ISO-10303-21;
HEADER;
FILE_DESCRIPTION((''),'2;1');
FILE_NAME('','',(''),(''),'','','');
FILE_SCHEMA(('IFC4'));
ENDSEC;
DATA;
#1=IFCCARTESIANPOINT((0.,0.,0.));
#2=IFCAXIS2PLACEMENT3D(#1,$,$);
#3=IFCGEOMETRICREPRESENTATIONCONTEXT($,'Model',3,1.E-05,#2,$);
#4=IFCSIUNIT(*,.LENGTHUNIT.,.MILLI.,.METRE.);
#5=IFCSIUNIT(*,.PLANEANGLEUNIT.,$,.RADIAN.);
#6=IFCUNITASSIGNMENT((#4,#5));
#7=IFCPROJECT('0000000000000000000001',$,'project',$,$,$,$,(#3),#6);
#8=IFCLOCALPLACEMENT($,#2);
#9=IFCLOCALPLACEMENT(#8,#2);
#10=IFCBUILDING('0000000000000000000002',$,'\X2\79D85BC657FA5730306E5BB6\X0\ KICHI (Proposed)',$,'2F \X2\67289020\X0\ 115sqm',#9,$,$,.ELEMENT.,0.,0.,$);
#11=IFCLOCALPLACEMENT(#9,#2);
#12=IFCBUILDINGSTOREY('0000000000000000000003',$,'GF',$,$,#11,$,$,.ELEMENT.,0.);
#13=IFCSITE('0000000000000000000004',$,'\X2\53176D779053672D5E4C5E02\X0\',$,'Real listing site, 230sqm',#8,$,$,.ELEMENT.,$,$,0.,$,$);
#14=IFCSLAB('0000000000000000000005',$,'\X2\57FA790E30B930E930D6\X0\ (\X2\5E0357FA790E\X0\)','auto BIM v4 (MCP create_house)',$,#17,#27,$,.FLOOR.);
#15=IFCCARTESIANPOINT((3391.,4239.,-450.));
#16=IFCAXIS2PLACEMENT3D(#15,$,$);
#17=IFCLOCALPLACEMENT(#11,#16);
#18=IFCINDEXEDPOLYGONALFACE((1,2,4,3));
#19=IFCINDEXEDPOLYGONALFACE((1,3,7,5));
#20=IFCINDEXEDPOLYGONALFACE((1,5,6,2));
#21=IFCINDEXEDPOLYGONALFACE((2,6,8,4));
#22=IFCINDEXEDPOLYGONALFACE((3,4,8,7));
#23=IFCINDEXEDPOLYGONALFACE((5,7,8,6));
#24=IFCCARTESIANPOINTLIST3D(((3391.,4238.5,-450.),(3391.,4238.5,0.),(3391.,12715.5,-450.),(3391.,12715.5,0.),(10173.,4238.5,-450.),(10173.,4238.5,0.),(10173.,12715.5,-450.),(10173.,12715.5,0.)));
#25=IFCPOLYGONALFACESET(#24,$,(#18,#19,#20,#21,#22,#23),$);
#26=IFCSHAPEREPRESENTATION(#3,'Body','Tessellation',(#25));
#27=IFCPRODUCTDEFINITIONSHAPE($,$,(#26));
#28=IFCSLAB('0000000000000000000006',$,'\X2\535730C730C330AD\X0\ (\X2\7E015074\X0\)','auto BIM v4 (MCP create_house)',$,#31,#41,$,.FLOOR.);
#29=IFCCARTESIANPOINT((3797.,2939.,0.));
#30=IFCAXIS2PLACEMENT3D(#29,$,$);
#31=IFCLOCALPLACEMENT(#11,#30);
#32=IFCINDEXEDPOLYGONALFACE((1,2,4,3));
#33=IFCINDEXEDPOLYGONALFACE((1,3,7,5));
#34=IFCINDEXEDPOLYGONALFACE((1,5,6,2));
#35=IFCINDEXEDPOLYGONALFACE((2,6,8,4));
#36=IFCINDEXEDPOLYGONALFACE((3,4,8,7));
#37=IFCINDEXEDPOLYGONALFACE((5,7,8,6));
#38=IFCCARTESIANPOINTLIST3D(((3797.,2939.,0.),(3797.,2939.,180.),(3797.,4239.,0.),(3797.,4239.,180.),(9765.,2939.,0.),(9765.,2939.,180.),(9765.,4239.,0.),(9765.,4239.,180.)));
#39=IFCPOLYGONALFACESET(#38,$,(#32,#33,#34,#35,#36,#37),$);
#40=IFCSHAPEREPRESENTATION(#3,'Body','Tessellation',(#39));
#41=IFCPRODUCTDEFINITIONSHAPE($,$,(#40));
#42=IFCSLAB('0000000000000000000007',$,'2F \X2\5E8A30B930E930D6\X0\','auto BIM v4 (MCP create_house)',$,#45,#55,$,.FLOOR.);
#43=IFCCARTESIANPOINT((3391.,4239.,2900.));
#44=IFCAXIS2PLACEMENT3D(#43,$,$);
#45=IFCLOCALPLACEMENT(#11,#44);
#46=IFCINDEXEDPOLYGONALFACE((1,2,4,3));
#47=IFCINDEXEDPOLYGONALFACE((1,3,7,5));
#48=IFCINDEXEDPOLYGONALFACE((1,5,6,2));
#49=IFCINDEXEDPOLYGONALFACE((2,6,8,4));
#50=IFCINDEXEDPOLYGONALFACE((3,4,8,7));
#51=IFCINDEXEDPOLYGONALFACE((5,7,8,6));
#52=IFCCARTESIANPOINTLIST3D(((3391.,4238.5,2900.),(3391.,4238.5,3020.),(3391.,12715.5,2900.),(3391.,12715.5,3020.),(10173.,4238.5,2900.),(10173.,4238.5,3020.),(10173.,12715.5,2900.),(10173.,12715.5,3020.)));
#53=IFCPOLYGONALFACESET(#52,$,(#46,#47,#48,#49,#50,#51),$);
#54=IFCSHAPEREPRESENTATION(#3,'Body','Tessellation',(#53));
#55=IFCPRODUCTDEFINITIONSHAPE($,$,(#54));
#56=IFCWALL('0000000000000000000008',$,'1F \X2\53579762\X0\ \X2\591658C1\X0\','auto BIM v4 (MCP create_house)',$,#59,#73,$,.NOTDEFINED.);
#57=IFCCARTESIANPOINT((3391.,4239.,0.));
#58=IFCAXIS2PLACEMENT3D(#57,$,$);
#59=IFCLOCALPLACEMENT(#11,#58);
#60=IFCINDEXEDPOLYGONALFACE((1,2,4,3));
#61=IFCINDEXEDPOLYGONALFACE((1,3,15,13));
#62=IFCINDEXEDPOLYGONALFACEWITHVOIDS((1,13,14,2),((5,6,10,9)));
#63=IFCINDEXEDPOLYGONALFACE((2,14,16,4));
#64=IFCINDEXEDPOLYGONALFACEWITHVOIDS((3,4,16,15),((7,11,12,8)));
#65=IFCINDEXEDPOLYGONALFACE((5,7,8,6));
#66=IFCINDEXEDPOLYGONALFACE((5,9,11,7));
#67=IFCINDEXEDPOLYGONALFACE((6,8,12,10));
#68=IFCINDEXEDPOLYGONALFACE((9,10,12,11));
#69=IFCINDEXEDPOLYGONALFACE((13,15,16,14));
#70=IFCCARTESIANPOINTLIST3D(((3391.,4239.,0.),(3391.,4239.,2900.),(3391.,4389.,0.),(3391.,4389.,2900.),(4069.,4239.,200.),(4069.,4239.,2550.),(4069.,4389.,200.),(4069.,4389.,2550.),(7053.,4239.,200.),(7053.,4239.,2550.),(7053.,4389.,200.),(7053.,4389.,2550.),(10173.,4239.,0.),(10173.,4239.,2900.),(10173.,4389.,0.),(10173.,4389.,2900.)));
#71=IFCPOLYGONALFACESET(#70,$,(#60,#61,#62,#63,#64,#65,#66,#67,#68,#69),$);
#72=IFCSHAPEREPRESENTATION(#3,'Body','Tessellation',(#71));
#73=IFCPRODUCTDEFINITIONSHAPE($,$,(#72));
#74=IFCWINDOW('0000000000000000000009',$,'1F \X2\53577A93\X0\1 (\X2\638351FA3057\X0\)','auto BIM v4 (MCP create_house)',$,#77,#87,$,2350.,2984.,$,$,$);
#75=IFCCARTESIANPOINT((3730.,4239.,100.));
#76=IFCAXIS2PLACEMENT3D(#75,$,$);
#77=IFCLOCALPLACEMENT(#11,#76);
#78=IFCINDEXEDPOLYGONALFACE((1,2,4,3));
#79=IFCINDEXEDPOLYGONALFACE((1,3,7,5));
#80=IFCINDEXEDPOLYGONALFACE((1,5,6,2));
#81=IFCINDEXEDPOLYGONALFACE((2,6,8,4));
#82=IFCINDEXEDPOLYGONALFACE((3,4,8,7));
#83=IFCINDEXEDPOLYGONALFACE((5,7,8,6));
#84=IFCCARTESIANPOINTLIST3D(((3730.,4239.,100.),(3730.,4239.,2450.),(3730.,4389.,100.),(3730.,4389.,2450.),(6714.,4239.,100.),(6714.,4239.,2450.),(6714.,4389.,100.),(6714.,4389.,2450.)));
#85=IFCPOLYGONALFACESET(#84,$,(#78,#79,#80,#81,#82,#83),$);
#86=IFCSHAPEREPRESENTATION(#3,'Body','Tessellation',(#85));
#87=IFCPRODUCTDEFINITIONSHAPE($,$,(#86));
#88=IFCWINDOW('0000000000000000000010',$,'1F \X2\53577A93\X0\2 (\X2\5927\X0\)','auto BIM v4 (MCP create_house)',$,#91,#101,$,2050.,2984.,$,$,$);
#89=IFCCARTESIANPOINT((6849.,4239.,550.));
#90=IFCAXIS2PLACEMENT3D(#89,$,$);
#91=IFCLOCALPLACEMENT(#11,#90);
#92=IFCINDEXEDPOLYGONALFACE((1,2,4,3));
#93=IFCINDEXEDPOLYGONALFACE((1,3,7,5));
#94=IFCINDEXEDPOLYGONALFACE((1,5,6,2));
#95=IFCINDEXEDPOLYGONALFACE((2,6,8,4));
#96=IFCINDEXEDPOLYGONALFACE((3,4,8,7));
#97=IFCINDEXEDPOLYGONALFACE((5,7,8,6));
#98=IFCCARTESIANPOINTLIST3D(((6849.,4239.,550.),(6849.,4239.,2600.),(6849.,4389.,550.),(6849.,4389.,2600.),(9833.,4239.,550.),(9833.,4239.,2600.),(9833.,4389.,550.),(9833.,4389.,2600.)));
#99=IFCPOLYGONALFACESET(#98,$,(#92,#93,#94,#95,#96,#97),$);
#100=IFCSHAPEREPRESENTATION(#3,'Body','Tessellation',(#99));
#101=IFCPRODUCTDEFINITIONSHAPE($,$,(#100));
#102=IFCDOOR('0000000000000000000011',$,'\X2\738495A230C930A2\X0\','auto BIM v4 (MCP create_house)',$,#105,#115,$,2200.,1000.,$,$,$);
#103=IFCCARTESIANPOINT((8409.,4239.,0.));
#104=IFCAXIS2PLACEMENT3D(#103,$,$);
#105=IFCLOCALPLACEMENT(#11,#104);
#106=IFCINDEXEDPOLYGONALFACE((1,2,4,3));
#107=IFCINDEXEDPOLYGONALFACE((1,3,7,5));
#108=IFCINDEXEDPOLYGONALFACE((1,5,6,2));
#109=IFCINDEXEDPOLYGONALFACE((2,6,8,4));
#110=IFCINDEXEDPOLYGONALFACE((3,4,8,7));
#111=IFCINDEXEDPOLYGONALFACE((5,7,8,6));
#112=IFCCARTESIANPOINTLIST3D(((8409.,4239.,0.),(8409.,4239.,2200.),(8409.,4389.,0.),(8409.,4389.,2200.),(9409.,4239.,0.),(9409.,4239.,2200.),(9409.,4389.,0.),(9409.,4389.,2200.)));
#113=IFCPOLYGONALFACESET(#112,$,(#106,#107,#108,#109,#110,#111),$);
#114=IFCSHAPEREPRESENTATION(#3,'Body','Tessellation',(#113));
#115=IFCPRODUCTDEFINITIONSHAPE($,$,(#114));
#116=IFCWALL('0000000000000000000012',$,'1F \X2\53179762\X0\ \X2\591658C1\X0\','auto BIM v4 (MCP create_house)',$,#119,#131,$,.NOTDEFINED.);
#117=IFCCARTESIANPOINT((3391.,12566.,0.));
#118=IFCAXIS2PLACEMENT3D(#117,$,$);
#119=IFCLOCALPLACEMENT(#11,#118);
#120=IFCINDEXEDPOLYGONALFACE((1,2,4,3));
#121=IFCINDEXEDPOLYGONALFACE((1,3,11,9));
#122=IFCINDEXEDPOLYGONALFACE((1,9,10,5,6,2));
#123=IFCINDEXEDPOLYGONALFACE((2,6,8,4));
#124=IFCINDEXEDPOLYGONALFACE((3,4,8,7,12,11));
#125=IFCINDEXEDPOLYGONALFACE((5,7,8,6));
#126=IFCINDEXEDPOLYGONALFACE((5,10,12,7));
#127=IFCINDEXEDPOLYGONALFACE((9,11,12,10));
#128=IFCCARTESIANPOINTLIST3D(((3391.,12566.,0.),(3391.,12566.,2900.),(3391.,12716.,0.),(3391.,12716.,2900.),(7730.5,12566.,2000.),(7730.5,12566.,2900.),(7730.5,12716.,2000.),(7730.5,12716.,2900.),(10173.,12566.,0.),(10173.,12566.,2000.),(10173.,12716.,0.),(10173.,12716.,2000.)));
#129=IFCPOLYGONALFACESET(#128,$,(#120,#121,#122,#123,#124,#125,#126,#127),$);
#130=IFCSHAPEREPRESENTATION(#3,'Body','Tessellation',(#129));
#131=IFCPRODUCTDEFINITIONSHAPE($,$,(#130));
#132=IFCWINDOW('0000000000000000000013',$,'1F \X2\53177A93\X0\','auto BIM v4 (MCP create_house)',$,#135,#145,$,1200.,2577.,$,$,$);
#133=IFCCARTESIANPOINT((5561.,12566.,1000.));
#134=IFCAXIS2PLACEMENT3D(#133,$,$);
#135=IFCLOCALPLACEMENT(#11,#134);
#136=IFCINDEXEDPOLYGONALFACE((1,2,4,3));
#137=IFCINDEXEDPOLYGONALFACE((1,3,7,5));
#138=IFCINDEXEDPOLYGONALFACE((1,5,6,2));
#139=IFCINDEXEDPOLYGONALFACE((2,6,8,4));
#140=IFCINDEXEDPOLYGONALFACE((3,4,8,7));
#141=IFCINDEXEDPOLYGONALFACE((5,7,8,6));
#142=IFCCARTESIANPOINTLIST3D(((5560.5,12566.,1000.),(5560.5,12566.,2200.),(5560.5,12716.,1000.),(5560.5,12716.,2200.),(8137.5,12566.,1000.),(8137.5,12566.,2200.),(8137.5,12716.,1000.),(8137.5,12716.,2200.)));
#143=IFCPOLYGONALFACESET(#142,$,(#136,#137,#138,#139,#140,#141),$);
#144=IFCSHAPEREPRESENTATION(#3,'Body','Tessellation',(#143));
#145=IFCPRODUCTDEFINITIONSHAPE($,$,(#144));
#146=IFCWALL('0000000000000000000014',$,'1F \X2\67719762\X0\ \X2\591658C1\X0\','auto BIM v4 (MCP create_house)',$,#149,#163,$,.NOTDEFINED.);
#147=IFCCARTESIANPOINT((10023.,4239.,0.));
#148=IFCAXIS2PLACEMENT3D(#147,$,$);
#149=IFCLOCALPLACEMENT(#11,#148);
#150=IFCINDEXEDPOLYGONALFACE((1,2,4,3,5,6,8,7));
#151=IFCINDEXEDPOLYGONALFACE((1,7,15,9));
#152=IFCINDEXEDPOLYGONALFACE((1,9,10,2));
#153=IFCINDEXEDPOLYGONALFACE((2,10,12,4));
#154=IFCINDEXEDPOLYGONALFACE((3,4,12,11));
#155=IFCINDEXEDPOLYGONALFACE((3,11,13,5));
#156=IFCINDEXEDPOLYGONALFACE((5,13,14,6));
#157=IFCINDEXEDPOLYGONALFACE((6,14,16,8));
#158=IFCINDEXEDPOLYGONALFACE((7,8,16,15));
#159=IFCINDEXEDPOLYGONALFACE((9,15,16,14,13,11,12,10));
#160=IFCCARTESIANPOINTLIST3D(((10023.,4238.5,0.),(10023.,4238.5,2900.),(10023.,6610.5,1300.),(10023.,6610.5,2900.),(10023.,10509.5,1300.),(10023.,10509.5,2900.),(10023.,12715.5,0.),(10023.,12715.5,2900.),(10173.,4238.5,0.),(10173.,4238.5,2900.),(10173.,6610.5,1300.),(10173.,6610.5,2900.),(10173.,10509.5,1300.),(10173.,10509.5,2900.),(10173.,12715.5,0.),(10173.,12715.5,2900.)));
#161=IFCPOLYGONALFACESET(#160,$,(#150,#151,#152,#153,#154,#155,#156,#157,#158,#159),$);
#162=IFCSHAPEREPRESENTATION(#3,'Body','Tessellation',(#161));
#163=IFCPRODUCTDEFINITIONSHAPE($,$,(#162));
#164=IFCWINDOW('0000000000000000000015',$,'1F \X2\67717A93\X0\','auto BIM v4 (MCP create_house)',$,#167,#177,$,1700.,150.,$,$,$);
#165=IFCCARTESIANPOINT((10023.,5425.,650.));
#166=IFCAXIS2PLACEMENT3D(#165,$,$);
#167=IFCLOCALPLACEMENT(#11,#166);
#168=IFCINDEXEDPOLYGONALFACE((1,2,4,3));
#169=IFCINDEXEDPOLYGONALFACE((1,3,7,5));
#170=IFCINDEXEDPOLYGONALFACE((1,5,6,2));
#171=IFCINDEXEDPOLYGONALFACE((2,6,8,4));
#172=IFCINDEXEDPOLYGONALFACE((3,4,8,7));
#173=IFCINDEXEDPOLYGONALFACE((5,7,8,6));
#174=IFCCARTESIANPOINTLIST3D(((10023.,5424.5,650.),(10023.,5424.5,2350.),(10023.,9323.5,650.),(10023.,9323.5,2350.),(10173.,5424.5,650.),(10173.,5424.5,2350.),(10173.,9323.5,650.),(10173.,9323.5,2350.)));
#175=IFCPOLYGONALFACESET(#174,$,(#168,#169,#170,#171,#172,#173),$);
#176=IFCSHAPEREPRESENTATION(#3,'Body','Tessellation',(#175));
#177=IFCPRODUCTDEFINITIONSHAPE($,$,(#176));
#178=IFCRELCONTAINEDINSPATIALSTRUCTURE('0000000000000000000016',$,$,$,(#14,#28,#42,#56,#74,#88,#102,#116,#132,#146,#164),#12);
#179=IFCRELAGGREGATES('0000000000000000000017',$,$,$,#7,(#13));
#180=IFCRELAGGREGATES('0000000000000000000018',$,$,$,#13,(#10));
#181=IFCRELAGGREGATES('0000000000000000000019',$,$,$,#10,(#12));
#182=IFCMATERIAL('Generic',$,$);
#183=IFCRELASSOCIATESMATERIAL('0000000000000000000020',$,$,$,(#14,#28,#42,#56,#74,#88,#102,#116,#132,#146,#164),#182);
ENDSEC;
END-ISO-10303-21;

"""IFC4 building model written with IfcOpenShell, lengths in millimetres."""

from ifc_helpers import new_model, si_unit, frame, frame_2d, origin, place, context, project, spatial, rectangle, extrude, material, element, fill, save


model = new_model("IFC4")

# Units and contexts
model_context = context("Model", 3, precision=1e-05, world=origin())
ifc_project = project(units=[si_unit("LENGTHUNIT", "METRE", prefix="MILLI"), si_unit("PLANEANGLEUNIT", "RADIAN")], contexts=[model_context])

# Site, building, storey
site_placement = place(None, origin())
site = spatial("IfcSite", under=ifc_project, at=site_placement, Name="北海道札幌市", ObjectType="Real listing site, 230sqm", CompositionType="ELEMENT", RefElevation=0.0)
building_placement = place(site_placement, origin())
building = spatial("IfcBuilding", under=site, at=building_placement, Name="秘密基地の家 KICHI (Proposed)", ObjectType="2F 木造 115sqm", CompositionType="ELEMENT", ElevationOfRefHeight=0.0, ElevationOfTerrain=0.0)
storey_placement = place(building_placement, origin())
storey = spatial("IfcBuildingStorey", under=building, at=storey_placement, Name="GF", CompositionType="ELEMENT", Elevation=0.0)

# Slabs
ifc_material = material(Name="Generic")
slab_1_placement = place(storey_placement, frame((3391.0, 4239.0, -450.0)))
element("IfcSlab", 1, at=slab_1_placement, inside=storey, material=ifc_material, Name="基礎スラブ (布基礎)", Description="auto BIM v4 (MCP create_house)", PredefinedType="FLOOR", context=model_context, shape_type="SweptSolid", body=[
    extrude(rectangle(XDim=6782.0, YDim=8477.0, at=frame_2d((3391.0, 4238.0))), frame((3391.0, 4239.0, -450.0)), (0.0, 0.0, 1.0), 450.0),
])
slab_2_placement = place(storey_placement, frame((3797.0, 2939.0, 0.0)))
element("IfcSlab", 2, at=slab_2_placement, inside=storey, material=ifc_material, Name="南デッキ (縁側)", Description="auto BIM v4 (MCP create_house)", PredefinedType="FLOOR", context=model_context, shape_type="SweptSolid", body=[
    extrude(rectangle(XDim=5968.0, YDim=1300.0, at=frame_2d((2984.0, 650.0))), frame((3797.0, 2939.0, 0.0)), (0.0, 0.0, 1.0), 180.0),
])
slab_3_placement = place(storey_placement, frame((3391.0, 4239.0, 2900.0)))
element("IfcSlab", 3, at=slab_3_placement, inside=storey, material=ifc_material, Name="2F 床スラブ", Description="auto BIM v4 (MCP create_house)", PredefinedType="FLOOR", context=model_context, shape_type="SweptSolid", body=[
    extrude(rectangle(XDim=6782.0, YDim=8477.0, at=frame_2d((3391.0, 4238.0))), frame((3391.0, 4239.0, 2900.0)), (0.0, 0.0, 1.0), 120.0),
])

# Wall, openings, windows, door
wall_1_placement = place(storey_placement, frame((3391.0, 4239.0, 0.0)))
wall_1 = element("IfcWall", 4, at=wall_1_placement, inside=storey, material=ifc_material, Name="1F 南面 外壁", Description="auto BIM v4 (MCP create_house)", PredefinedType="NOTDEFINED", context=model_context, shape_type="SweptSolid", body=[
    extrude(rectangle(XDim=6782.0, YDim=150.0, at=frame_2d((3391.0, 75.0))), frame((3391.0, 4239.0, 0.0)), (0.0, 0.0, 1.0), 2900.0),
])
opening_1_placement = place(storey_placement, frame((3730.0, 4239.0, 100.0)))
opening_1 = element("IfcOpeningElement", 5, at=opening_1_placement, cuts=wall_1, PredefinedType="NOTDEFINED", context=model_context, shape_type="SweptSolid", body=[
    extrude(rectangle(XDim=2984.0, YDim=150.0, at=frame_2d((1492.0, 75.0))), frame((3730.0, 4239.0, 100.0)), (0.0, 0.0, 1.0), 2350.0),
])
opening_2_placement = place(storey_placement, frame((6849.0, 4239.0, 550.0)))
opening_2 = element("IfcOpeningElement", 6, at=opening_2_placement, cuts=wall_1, PredefinedType="NOTDEFINED", context=model_context, shape_type="SweptSolid", body=[
    extrude(rectangle(XDim=2984.0, YDim=150.0, at=frame_2d((1492.0, 75.0))), frame((6849.0, 4239.0, 550.0)), (0.0, 0.0, 1.0), 2050.0),
])
opening_3_placement = place(storey_placement, frame((8409.0, 4239.0, 0.0)))
opening_3 = element("IfcOpeningElement", 7, at=opening_3_placement, cuts=wall_1, PredefinedType="NOTDEFINED", context=model_context, shape_type="SweptSolid", body=[
    extrude(rectangle(XDim=1000.0, YDim=150.0, at=frame_2d((500.0, 75.0))), frame((8409.0, 4239.0, 0.0)), (0.0, 0.0, 1.0), 2200.0),
])
window_1_placement = place(storey_placement, frame((3730.0, 4239.0, 100.0)))
window_1 = element("IfcWindow", 8, at=window_1_placement, inside=storey, material=ifc_material, Name="1F 南窓1 (掃出し)", Description="auto BIM v4 (MCP create_house)", OverallHeight=2350.0, OverallWidth=2984.0, context=model_context, shape_type="SweptSolid", body=[
    extrude(rectangle(XDim=2984.0, YDim=150.0, at=frame_2d((1492.0, 75.0))), frame((3730.0, 4239.0, 100.0)), (0.0, 0.0, 1.0), 2350.0),
])
fill(opening_1, window_1)
window_2_placement = place(storey_placement, frame((6849.0, 4239.0, 550.0)))
window_2 = element("IfcWindow", 9, at=window_2_placement, inside=storey, material=ifc_material, Name="1F 南窓2 (大)", Description="auto BIM v4 (MCP create_house)", OverallHeight=2050.0, OverallWidth=2984.0, context=model_context, shape_type="SweptSolid", body=[
    extrude(rectangle(XDim=2984.0, YDim=150.0, at=frame_2d((1492.0, 75.0))), frame((6849.0, 4239.0, 550.0)), (0.0, 0.0, 1.0), 2050.0),
])
fill(opening_2, window_2)
door_1_placement = place(storey_placement, frame((8409.0, 4239.0, 0.0)))
door_1 = element("IfcDoor", 10, at=door_1_placement, inside=storey, material=ifc_material, Name="玄関ドア", Description="auto BIM v4 (MCP create_house)", OverallHeight=2200.0, OverallWidth=1000.0, context=model_context, shape_type="SweptSolid", body=[
    extrude(rectangle(XDim=1000.0, YDim=150.0, at=frame_2d((500.0, 75.0))), frame((8409.0, 4239.0, 0.0)), (0.0, 0.0, 1.0), 2200.0),
])
fill(opening_3, door_1)

# Walls, openings, windows
wall_2_placement = place(storey_placement, frame((3391.0, 12566.0, 0.0)))
wall_2 = element("IfcWall", 11, at=wall_2_placement, inside=storey, material=ifc_material, Name="1F 北面 外壁", Description="auto BIM v4 (MCP create_house)", PredefinedType="NOTDEFINED", context=model_context, shape_type="SweptSolid", body=[
    extrude(rectangle(XDim=6782.0, YDim=150.0, at=frame_2d((3391.0, 75.0))), frame((3391.0, 12566.0, 0.0)), (0.0, 0.0, 1.0), 2900.0),
])
opening_4_placement = place(storey_placement, frame((5561.0, 12566.0, 1000.0)))
opening_4 = element("IfcOpeningElement", 12, at=opening_4_placement, cuts=wall_2, PredefinedType="NOTDEFINED", context=model_context, shape_type="SweptSolid", body=[
    extrude(rectangle(XDim=2577.0, YDim=150.0, at=frame_2d((1288.0, 75.0))), frame((5561.0, 12566.0, 1000.0)), (0.0, 0.0, 1.0), 1200.0),
])
window_3_placement = place(storey_placement, frame((5561.0, 12566.0, 1000.0)))
window_3 = element("IfcWindow", 13, at=window_3_placement, inside=storey, material=ifc_material, Name="1F 北窓", Description="auto BIM v4 (MCP create_house)", OverallHeight=1200.0, OverallWidth=2577.0, context=model_context, shape_type="SweptSolid", body=[
    extrude(rectangle(XDim=2577.0, YDim=150.0, at=frame_2d((1288.0, 75.0))), frame((5561.0, 12566.0, 1000.0)), (0.0, 0.0, 1.0), 1200.0),
])
fill(opening_4, window_3)
wall_3_placement = place(storey_placement, frame((10023.0, 4239.0, 0.0)))
wall_3 = element("IfcWall", 14, at=wall_3_placement, inside=storey, material=ifc_material, Name="1F 東面 外壁", Description="auto BIM v4 (MCP create_house)", PredefinedType="NOTDEFINED", context=model_context, shape_type="SweptSolid", body=[
    extrude(rectangle(XDim=150.0, YDim=8477.0, at=frame_2d((75.0, 4238.0))), frame((10023.0, 4239.0, 0.0)), (0.0, 0.0, 1.0), 2900.0),
])
opening_5_placement = place(storey_placement, frame((10023.0, 5425.0, 650.0)))
opening_5 = element("IfcOpeningElement", 15, at=opening_5_placement, cuts=wall_3, PredefinedType="NOTDEFINED", context=model_context, shape_type="SweptSolid", body=[
    extrude(rectangle(XDim=150.0, YDim=3899.0, at=frame_2d((75.0, 1949.0))), frame((10023.0, 5425.0, 650.0)), (0.0, 0.0, 1.0), 1700.0),
])
window_4_placement = place(storey_placement, frame((10023.0, 5425.0, 650.0)))
window_4 = element("IfcWindow", 16, at=window_4_placement, inside=storey, material=ifc_material, Name="1F 東窓", Description="auto BIM v4 (MCP create_house)", OverallHeight=1700.0, OverallWidth=150.0, context=model_context, shape_type="SweptSolid", body=[
    extrude(rectangle(XDim=150.0, YDim=3899.0, at=frame_2d((75.0, 1949.0))), frame((10023.0, 5425.0, 650.0)), (0.0, 0.0, 1.0), 1700.0),
])
fill(opening_5, window_4)

save(model, "model.ifc")
